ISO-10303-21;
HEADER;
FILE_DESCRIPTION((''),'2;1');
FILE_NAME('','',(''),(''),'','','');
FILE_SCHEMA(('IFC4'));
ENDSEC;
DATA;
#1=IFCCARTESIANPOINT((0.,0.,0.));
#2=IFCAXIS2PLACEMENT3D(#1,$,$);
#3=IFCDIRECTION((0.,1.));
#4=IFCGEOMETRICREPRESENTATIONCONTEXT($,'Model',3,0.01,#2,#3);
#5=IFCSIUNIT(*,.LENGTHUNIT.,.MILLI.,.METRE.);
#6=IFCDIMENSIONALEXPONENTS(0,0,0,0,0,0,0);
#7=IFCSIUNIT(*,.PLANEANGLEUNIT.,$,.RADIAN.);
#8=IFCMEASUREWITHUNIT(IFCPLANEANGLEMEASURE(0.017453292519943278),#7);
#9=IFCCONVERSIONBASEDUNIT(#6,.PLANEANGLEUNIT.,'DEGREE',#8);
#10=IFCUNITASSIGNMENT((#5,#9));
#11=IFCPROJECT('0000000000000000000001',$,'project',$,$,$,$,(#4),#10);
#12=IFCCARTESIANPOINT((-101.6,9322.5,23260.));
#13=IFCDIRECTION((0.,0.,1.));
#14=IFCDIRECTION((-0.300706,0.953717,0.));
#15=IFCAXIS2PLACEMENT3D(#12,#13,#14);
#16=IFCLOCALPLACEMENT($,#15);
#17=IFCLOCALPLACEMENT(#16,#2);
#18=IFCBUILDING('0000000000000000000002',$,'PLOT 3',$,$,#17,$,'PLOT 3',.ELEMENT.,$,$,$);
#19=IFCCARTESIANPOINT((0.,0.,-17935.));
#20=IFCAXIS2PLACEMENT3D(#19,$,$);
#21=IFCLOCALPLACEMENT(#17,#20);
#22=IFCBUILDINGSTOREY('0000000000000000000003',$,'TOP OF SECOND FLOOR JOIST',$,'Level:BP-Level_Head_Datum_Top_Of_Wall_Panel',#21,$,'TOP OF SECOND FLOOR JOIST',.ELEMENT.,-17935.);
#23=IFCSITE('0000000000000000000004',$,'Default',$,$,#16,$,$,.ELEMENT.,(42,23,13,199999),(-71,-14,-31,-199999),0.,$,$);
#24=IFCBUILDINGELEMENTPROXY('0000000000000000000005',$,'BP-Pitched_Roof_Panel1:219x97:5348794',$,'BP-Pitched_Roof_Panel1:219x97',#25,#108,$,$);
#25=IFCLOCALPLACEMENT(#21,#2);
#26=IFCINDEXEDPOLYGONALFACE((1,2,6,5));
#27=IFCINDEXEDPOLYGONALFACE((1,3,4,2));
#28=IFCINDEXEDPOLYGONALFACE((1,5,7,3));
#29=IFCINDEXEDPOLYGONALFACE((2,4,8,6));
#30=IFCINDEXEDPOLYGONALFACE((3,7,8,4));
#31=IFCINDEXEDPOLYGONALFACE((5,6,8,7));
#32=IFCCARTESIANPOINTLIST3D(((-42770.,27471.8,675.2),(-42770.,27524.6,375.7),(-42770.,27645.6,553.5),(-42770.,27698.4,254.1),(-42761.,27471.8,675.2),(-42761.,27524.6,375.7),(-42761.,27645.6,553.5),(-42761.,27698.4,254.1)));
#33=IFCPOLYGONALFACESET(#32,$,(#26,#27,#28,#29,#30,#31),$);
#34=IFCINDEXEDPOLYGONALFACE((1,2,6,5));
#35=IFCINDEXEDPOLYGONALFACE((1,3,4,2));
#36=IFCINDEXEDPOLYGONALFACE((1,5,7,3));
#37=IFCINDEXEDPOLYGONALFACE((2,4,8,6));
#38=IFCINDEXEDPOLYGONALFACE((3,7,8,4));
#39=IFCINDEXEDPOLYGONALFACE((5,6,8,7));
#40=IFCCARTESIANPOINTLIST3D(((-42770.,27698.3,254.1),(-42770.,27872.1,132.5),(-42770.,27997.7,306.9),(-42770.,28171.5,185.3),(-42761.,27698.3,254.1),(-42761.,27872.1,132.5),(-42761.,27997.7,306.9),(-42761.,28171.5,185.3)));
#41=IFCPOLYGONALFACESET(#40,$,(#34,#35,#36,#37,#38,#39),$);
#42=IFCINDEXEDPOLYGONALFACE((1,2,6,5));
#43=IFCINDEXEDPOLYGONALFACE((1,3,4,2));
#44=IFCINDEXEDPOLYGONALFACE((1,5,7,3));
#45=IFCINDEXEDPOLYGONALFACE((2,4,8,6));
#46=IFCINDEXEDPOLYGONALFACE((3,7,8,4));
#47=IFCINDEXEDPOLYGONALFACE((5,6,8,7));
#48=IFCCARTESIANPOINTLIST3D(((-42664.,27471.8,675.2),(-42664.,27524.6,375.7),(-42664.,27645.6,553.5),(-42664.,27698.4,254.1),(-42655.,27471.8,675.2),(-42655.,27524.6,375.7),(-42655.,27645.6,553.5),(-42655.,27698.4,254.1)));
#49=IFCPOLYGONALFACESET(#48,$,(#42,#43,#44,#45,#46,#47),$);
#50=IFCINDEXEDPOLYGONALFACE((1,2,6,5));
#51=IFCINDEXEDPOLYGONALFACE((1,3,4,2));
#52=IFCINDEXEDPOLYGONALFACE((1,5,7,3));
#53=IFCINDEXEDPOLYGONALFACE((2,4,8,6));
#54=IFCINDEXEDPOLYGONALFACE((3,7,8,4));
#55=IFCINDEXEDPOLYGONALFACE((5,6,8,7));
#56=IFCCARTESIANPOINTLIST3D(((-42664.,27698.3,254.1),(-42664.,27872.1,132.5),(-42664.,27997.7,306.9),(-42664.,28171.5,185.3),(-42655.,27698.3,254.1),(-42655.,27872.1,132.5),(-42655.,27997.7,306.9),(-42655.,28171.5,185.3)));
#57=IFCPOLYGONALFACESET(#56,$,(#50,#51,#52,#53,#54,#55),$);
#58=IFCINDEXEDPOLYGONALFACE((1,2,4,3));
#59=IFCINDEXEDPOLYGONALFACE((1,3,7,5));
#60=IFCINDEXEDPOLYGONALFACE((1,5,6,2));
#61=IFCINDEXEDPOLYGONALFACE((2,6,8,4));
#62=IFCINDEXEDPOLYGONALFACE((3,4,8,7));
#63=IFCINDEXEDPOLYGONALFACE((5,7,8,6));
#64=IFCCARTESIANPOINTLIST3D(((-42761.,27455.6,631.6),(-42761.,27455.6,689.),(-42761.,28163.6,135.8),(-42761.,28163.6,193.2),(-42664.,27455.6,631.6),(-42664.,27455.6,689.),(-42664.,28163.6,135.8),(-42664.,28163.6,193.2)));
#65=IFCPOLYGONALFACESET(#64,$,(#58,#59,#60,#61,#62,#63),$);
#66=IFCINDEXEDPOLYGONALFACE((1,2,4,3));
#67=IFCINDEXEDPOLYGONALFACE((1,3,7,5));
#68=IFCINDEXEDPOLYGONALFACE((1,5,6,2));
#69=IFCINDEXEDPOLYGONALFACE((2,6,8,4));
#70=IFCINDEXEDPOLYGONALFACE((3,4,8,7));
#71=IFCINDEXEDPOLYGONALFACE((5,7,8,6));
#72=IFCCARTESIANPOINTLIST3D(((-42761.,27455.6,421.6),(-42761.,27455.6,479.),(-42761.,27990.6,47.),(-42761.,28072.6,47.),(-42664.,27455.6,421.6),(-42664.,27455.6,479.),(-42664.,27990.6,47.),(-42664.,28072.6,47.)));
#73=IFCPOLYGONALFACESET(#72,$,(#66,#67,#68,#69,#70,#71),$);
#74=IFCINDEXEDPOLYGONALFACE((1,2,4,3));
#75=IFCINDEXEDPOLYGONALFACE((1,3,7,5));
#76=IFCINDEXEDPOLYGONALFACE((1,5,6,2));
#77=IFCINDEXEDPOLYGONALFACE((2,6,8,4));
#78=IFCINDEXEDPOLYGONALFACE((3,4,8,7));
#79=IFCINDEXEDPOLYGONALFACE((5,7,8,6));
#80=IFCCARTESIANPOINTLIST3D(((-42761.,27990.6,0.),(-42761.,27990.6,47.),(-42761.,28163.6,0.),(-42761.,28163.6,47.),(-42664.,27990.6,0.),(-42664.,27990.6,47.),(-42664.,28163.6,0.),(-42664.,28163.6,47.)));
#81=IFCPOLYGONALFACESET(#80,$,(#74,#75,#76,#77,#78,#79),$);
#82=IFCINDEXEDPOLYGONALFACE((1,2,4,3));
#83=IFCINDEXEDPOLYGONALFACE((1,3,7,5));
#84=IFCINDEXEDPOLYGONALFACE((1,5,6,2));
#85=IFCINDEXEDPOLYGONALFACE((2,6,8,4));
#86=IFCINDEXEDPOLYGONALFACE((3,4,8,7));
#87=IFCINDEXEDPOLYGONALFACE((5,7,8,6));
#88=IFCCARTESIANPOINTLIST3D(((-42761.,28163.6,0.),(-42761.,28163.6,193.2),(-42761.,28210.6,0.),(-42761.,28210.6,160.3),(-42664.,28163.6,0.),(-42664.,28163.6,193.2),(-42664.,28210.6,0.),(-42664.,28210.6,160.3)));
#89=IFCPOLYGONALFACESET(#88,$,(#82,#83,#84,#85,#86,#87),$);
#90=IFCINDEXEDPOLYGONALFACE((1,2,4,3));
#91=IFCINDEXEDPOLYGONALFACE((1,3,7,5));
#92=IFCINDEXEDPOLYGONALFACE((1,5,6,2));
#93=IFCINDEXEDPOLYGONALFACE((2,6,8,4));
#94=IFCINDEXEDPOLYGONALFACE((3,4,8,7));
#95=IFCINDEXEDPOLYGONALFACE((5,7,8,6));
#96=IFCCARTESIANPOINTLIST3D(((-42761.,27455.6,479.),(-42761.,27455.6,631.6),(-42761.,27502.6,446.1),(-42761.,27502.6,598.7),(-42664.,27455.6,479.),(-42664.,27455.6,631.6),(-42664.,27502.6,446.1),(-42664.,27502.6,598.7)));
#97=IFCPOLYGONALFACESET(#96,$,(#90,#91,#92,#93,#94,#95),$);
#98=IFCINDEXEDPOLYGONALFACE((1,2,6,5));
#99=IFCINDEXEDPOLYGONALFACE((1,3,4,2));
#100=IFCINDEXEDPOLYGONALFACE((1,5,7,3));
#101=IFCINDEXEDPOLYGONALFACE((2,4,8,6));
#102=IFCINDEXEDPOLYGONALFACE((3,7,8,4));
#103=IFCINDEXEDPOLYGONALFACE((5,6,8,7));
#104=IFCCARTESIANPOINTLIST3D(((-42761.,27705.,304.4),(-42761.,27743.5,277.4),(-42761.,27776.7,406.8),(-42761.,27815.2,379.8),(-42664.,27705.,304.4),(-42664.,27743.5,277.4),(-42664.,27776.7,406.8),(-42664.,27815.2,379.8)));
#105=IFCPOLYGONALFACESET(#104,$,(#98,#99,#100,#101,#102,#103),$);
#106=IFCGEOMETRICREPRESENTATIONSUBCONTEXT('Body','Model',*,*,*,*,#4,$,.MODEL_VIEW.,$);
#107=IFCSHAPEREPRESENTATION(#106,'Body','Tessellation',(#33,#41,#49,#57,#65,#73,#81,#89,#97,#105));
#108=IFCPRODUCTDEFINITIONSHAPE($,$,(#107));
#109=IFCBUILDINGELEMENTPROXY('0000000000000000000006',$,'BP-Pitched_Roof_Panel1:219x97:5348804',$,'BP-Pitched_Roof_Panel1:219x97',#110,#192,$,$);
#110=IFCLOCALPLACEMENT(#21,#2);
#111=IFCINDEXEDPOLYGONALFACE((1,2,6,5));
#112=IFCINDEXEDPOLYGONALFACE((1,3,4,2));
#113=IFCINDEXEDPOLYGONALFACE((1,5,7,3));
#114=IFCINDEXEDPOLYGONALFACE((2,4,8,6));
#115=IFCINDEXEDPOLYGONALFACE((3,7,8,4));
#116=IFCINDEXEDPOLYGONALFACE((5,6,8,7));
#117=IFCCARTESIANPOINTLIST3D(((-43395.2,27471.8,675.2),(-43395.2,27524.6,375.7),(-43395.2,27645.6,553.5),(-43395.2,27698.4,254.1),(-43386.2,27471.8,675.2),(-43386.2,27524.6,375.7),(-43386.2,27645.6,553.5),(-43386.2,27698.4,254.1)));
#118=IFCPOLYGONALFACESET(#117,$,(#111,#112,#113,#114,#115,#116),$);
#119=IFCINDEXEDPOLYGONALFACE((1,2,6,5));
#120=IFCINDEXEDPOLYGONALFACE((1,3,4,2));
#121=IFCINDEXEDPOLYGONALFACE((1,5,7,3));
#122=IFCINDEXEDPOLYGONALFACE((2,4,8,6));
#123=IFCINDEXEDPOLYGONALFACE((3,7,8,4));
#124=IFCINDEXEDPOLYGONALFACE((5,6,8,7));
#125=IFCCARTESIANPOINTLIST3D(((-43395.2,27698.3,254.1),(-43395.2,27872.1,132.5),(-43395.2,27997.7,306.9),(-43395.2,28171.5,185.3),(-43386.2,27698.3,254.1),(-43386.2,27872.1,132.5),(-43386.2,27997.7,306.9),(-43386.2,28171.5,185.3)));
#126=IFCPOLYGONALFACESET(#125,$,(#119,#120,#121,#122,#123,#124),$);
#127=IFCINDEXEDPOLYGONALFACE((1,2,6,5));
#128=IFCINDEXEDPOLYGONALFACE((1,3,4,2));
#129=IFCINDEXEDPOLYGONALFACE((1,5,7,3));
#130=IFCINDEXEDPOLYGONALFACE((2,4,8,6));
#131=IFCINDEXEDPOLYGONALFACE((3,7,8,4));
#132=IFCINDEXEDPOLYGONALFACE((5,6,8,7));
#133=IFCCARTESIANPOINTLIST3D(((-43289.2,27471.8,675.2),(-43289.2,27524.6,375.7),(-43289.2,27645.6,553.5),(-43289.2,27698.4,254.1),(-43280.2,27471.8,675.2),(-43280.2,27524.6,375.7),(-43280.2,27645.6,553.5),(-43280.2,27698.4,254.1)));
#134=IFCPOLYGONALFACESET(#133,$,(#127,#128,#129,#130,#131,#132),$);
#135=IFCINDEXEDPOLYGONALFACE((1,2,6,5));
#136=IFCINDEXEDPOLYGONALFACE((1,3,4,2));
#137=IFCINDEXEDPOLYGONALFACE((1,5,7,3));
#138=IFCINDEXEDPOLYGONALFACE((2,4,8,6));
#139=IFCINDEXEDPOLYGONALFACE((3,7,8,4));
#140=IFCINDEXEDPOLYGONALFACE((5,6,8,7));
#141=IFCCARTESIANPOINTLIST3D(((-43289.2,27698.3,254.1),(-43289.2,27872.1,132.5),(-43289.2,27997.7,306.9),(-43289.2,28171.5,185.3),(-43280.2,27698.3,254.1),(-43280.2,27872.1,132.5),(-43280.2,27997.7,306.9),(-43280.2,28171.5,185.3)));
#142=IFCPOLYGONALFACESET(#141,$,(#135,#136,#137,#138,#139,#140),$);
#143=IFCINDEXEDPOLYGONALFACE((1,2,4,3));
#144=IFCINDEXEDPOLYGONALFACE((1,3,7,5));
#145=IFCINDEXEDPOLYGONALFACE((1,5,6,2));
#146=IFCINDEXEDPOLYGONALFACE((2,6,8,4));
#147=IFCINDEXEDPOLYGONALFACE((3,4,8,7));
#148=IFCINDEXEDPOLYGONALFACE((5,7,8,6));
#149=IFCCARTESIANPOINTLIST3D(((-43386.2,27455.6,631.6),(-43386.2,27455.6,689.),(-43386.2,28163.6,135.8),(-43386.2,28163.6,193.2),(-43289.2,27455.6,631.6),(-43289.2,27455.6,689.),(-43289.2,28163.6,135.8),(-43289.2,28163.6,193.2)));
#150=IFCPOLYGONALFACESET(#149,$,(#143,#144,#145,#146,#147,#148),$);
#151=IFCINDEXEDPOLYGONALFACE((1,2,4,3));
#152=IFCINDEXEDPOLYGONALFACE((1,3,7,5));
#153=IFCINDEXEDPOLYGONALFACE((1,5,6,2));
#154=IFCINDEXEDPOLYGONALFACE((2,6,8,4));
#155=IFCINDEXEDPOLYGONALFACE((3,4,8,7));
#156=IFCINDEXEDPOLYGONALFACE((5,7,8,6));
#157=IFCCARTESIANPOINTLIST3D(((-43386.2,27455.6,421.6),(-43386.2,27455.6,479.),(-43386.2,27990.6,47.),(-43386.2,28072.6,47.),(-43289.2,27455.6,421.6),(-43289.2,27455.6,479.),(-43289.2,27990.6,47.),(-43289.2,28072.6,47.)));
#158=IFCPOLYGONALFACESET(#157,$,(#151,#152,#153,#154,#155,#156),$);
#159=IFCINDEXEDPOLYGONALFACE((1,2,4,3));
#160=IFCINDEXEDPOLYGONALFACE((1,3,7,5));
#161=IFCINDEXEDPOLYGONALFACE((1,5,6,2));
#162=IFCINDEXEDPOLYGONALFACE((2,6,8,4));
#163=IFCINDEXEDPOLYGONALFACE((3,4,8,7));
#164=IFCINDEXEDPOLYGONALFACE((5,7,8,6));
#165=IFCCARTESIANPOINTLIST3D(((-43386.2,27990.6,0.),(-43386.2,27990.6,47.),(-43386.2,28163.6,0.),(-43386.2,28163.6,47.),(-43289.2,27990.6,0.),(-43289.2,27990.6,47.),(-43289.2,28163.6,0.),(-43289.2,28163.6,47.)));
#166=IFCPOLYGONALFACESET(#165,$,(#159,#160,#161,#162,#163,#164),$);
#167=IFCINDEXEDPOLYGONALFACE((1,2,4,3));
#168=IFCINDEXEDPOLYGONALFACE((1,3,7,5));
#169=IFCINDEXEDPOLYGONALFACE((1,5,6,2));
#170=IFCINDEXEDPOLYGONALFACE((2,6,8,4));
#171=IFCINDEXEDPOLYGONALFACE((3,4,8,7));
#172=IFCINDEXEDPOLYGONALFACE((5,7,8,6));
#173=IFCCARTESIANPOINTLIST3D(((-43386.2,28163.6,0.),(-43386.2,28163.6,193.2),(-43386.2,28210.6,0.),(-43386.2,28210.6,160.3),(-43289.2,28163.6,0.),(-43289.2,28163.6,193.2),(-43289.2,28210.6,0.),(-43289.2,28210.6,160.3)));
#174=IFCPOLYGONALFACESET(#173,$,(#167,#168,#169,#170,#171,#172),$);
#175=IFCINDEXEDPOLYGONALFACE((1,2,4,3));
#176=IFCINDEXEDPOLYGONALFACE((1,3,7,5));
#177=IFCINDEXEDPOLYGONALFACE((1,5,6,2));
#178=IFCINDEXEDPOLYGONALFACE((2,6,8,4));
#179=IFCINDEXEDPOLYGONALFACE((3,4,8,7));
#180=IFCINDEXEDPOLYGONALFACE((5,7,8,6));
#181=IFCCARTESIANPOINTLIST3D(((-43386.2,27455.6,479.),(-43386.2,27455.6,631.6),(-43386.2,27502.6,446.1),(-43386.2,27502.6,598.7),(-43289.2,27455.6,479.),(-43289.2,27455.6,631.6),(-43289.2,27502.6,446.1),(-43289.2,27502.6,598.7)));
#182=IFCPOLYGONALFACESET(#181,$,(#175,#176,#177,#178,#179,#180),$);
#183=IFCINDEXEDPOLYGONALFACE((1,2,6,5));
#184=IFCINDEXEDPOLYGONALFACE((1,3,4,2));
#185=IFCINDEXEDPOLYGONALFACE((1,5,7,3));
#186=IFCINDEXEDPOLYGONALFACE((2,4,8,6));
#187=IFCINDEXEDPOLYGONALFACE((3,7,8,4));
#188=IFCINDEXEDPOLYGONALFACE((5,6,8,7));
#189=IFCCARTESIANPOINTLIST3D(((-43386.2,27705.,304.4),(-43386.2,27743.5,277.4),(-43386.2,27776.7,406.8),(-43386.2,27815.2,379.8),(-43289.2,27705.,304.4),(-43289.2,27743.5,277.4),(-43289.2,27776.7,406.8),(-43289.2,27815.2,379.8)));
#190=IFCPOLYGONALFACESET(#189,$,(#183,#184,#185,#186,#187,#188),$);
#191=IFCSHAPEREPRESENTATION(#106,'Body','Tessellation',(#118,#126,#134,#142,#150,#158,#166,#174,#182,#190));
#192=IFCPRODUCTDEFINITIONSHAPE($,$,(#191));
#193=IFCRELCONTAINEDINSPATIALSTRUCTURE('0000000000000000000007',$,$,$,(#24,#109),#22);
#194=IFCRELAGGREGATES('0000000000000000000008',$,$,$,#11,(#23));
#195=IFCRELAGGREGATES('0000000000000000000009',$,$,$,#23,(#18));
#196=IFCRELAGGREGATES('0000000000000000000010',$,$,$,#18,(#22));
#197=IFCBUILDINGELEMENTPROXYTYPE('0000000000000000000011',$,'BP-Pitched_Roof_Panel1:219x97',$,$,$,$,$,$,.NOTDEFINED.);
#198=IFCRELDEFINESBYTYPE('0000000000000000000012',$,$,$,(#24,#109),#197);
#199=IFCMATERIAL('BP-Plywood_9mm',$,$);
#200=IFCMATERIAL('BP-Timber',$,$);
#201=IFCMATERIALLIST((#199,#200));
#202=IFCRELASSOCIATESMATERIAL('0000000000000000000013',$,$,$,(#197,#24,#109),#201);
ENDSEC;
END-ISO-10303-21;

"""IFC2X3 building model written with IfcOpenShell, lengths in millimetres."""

from ifc_helpers import new_model, entity, si_unit, converted_unit, direction, frame, frame_2d, origin, origin_2d_with_axis, place, context, subcontext, project, spatial, polyline, rectangle, outline, extrude, source, transform, mapped, material, material_list, type_object, type_shapes, element, save


model = new_model("IFC2X3")

# Units and contexts
model_context = context("Model", 3, precision=0.01, world=origin(), true_north=direction((0.0, 1.0)))
body_context = subcontext(model_context, "Body", "Model", "MODEL_VIEW")
ifc_project = project(units=[si_unit("LENGTHUNIT", "METRE", prefix="MILLI"), converted_unit("PLANEANGLEUNIT", "DEGREE", entity("IfcPlaneAngleMeasure", 0.017453292519943278), si_unit("PLANEANGLEUNIT", "RADIAN"), dimensions=[0, 0, 0, 0, 0, 0, 0])], contexts=[model_context])

# Site, building, storey
site_placement = place(None, frame((-101.6, 9322.5, 23260.0), z_axis=(0.0, 0.0, 1.0), x_axis=(-0.300706, 0.953717, 0.0)))
site = spatial("IfcSite", under=ifc_project, at=site_placement, Name="Default", CompositionType="ELEMENT", RefLatitude=(42, 23, 13, 199999), RefLongitude=(-71, -14, -31, -199999), RefElevation=0.0)
building_placement = place(site_placement, origin())
building = spatial("IfcBuilding", under=site, at=building_placement, Name="PLOT 3", LongName="PLOT 3", CompositionType="ELEMENT")
storey_placement = place(building_placement, frame((0.0, 0.0, -17935.0)))
storey = spatial("IfcBuildingStorey", under=building, at=storey_placement, Name="TOP OF SECOND FLOOR JOIST", ObjectType="Level:BP-Level_Head_Datum_Top_Of_Wall_Panel", LongName="TOP OF SECOND FLOOR JOIST", CompositionType="ELEMENT", Elevation=-17935.0)

# Building element proxies
ifc_material_1 = material(Name="BP-Timber")
ifc_material_2 = material(Name="BP-Plywood_9mm")
ifc_material_list = material_list([ifc_material_2, ifc_material_1])
building_element_proxy_type_1 = type_object("IfcBuildingElementProxyType", Name="BP-Pitched_Roof_Panel1:219x97", PredefinedType="NOTDEFINED", material=ifc_material_list)
shared_shape_1 = source(origin(), body_context, "Body", "SweptSolid", [
    extrude(outline(polyline([(1.4, -107.5), (213.6, -107.5), (-1.4, 107.5), (-213.6, 107.5), (1.4, -107.5)])), frame((-2796.8, -3956.0, 464.6), z_axis=(0.0, 1.0, 0.0), x_axis=(-0.819152, 0.0, -0.573576)), (0.0, 0.0, 1.0), 9.0),
    extrude(outline(polyline([(-77.0, -75.0), (227.0, -75.0), (77.0, 75.0), (-227.0, 75.0), (-77.0, -75.0)])), frame((-3146.6, -3956.0, 219.7), z_axis=(0.0, 1.0, 0.0), x_axis=(-0.984808, 0.0, 0.173648)), (0.0, 0.0, 1.0), 9.0),
    extrude(outline(polyline([(1.4, -107.5), (213.6, -107.5), (-1.4, 107.5), (-213.6, 107.5), (1.4, -107.5)])), frame((-2796.8, -3850.0, 464.6), z_axis=(0.0, 1.0, 0.0), x_axis=(-0.819152, 0.0, -0.573576)), (0.0, 0.0, 1.0), 9.0),
    extrude(outline(polyline([(-77.0, -75.0), (227.0, -75.0), (77.0, 75.0), (-227.0, 75.0), (-77.0, -75.0)])), frame((-3146.6, -3850.0, 219.7), z_axis=(0.0, 1.0, 0.0), x_axis=(-0.984808, 0.0, 0.173648)), (0.0, 0.0, 1.0), 9.0),
    extrude(outline(polyline([(-276.6, -354.0), (-219.2, -354.0), (276.6, 354.0), (219.2, 354.0), (-276.6, -354.0)])), frame((-3021.3, -3947.0, 412.4), z_axis=(0.0, 1.0, 0.0), x_axis=(0.0, 0.0, -1.0)), (0.0, 0.0, 1.0), 97.0),
    extrude(outline(polyline([(-230.3, -288.0), (-173.0, -288.0), (201.6, 247.0), (201.6, 329.0), (-230.3, -288.0)])), frame((-2955.3, -3947.0, 248.6), z_axis=(0.0, 1.0, 0.0), x_axis=(0.0, 0.0, -1.0)), (0.0, 0.0, 1.0), 97.0),
    extrude(rectangle(XDim=173.0, YDim=97.0, at=origin_2d_with_axis()), frame((-3288.8, -3898.5, 0.0), z_axis=(0.0, 0.0, 1.0), x_axis=(-1.0, 0.0, 0.0)), (0.0, 0.0, 1.0), 47.0),
    extrude(outline(polyline([(22.0, -72.4), (79.4, -72.4), (-31.4, 85.9), (-69.9, 58.9), (22.0, -72.4)])), frame((-3398.8, -3947.0, 88.4), z_axis=(0.0, 1.0, 0.0), x_axis=(0.819152, 0.0, 0.573576)), (0.0, 0.0, 1.0), 97.0),
    extrude(outline(polyline([(15.1, -62.5), (72.5, -62.5), (-15.1, 62.5), (-72.5, 62.5), (15.1, -62.5)])), frame((-2690.8, -3947.0, 538.8), z_axis=(0.0, 1.0, 0.0), x_axis=(0.819152, 0.0, 0.573576)), (0.0, 0.0, 1.0), 97.0),
    extrude(rectangle(XDim=47.0, YDim=97.0, at=frame_2d((0.0, 0.0), x_axis=(1.0, 0.0))), frame((-2935.9, -3898.5, 290.9), z_axis=(-0.573576, 0.0, 0.819152), x_axis=(-0.819152, 0.0, -0.573576)), (0.0, 0.0, 1.0), 125.0),
])
type_shapes(building_element_proxy_type_1, [shared_shape_1])
for number, where, z_axis, x_axis, name in (
    (1, (-38814.0, 24788.3, 0.0), (0.0, 0.0, 1.0), (0.0, -1.0, 0.0), "BP-Pitched_Roof_Panel1:219x97:5348794"),
    (2, (-39439.2, 24788.3, 0.0), (0.0, 0.0, 1.0), (0.0, -1.0, 0.0), "BP-Pitched_Roof_Panel1:219x97:5348804"),
):
    element("IfcBuildingElementProxy", number, at=place(storey_placement, frame(where, z_axis=z_axis, x_axis=x_axis)), inside=storey, type_object=building_element_proxy_type_1, material=ifc_material_list, Name=name, ObjectType="BP-Pitched_Roof_Panel1:219x97", context=body_context, shape_type="MappedRepresentation", body=[
        mapped(shared_shape_1, transform((0.0, 0.0, 0.0), scale=1.0)),
    ])

save(model, "model.ifc")
